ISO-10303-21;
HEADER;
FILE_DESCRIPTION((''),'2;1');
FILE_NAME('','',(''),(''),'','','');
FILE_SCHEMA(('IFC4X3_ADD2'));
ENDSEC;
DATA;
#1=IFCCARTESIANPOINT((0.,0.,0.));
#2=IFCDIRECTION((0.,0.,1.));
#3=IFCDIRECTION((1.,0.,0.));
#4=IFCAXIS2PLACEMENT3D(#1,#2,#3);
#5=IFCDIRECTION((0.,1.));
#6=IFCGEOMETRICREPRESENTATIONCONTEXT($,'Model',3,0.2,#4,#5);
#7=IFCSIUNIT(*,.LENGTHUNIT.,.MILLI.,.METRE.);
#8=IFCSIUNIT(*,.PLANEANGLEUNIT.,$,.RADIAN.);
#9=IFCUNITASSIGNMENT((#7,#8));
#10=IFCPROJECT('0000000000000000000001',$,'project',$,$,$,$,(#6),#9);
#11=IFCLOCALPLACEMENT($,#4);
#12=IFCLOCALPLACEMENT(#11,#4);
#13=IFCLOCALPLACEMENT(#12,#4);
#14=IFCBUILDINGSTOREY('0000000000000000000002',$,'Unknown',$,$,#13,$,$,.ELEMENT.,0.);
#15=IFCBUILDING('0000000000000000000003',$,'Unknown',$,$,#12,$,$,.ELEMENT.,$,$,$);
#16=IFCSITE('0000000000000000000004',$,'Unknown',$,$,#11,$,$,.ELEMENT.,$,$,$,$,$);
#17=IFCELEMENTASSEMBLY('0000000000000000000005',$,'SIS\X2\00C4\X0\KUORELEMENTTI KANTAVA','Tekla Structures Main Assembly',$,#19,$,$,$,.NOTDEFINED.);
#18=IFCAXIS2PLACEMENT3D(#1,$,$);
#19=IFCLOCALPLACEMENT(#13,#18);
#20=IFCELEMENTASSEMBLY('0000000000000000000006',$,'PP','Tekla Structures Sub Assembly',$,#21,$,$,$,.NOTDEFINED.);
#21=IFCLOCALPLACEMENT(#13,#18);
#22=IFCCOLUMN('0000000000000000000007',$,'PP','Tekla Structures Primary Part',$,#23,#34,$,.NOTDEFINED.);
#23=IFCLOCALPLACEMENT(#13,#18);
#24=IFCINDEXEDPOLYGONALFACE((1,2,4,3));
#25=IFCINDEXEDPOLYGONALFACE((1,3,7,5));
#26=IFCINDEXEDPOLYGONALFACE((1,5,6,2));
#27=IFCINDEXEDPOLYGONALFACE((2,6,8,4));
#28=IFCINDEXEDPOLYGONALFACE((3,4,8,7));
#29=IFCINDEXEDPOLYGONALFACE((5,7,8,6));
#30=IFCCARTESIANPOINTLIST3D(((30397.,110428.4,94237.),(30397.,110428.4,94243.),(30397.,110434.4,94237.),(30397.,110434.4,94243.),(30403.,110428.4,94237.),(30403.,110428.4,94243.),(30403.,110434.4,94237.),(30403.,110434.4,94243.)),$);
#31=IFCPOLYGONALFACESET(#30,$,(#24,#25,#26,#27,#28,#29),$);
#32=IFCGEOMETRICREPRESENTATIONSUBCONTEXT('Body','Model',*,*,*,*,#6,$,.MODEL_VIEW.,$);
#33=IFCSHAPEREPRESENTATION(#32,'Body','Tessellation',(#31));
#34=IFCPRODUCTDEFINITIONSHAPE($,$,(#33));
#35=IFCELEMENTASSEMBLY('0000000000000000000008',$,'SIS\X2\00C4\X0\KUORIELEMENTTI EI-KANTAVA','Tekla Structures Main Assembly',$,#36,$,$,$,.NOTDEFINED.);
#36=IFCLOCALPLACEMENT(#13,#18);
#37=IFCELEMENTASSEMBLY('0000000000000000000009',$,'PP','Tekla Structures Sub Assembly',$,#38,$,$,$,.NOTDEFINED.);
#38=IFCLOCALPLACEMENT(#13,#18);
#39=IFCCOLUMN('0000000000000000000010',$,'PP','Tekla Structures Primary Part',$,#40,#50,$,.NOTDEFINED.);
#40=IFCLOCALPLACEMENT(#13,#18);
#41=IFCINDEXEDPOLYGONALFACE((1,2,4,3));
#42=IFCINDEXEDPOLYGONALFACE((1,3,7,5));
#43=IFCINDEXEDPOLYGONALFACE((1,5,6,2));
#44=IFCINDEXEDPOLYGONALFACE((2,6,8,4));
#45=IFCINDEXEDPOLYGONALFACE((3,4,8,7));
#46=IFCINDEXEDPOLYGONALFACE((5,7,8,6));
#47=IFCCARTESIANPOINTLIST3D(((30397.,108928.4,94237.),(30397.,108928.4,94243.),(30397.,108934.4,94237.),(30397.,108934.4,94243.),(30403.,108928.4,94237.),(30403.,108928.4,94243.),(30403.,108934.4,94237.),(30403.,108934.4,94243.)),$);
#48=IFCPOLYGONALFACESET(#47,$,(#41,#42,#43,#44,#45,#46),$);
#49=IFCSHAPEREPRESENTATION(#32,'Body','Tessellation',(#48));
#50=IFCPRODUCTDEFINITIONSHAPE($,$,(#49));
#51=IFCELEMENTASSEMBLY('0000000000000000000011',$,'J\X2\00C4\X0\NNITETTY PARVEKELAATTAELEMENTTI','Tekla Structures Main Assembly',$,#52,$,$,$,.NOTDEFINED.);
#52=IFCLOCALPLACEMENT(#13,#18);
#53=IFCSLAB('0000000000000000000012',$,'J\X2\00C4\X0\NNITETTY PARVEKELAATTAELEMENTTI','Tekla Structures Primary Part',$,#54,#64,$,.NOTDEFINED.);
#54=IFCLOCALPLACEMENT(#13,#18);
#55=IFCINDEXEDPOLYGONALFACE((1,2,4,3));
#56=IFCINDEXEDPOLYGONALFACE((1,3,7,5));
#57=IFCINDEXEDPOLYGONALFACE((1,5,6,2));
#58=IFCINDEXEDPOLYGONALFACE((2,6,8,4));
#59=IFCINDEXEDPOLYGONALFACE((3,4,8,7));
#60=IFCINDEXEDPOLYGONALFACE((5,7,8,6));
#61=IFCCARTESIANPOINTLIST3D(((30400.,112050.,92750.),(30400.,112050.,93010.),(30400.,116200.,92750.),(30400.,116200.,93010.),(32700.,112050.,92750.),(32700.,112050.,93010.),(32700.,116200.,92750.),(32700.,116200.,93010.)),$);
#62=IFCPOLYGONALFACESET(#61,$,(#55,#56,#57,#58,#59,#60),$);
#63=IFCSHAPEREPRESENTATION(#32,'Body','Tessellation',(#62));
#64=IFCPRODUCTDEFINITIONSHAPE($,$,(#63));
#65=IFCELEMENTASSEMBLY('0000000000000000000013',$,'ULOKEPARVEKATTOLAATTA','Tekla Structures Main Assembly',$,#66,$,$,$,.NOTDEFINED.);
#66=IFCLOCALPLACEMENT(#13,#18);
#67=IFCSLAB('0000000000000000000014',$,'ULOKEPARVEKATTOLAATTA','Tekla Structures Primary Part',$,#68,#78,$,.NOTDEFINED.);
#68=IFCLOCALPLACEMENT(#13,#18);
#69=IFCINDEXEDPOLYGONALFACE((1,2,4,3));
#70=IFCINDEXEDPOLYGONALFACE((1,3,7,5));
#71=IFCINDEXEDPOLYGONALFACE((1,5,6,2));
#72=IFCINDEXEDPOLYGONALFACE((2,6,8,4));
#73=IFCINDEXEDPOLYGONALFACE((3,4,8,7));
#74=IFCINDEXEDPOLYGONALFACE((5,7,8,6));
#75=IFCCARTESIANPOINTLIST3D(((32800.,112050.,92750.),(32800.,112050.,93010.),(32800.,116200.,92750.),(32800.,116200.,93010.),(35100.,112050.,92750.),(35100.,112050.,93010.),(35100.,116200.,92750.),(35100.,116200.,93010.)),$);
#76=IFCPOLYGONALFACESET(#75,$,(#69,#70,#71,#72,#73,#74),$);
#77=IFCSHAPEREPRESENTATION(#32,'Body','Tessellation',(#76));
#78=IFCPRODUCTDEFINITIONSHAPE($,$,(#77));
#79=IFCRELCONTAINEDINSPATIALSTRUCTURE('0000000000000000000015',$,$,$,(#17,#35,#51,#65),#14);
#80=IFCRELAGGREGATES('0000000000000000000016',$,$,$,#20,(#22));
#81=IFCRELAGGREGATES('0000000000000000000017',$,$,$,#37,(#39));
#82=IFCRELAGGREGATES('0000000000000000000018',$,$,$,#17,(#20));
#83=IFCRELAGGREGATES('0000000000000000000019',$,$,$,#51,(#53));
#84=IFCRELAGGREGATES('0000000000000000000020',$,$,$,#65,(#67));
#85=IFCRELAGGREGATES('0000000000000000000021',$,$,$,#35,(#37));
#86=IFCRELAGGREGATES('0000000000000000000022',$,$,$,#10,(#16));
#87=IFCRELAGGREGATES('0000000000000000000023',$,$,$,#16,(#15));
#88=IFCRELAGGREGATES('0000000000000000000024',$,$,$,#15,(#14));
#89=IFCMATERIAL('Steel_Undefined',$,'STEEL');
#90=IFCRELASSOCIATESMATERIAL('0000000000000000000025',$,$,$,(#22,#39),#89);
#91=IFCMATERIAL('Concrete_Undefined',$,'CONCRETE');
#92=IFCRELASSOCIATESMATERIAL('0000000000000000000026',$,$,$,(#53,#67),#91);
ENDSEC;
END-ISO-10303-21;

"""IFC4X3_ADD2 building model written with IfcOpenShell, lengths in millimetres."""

from ifc_helpers import new_model, si_unit, direction, frame, origin_with_axes, place, context, subcontext, project, spatial, line, indexed_curve, outline, extrude, material, element, aggregate, save


model = new_model("IFC4X3_ADD2")

# Units and contexts
model_context = context("Model", 3, precision=0.2, world=origin_with_axes(), true_north=direction((0.0, 1.0)))
body_context = subcontext(model_context, "Body", "Model", "MODEL_VIEW")
ifc_project = project(units=[si_unit("LENGTHUNIT", "METRE", prefix="MILLI"), si_unit("PLANEANGLEUNIT", "RADIAN")], contexts=[model_context])

# Site, building, storey
site_placement = place(None, origin_with_axes())
site = spatial("IfcSite", under=ifc_project, at=site_placement, Name="Unknown", CompositionType="ELEMENT")
building_placement = place(site_placement, origin_with_axes())
building = spatial("IfcBuilding", under=site, at=building_placement, Name="Unknown", CompositionType="ELEMENT")
storey_placement = place(building_placement, origin_with_axes())
storey = spatial("IfcBuildingStorey", under=building, at=storey_placement, Name="Unknown", CompositionType="ELEMENT", Elevation=0.0)

# Element assemblies, columns
assembly_1_placement = place(storey_placement, frame((28000.0, 110431.4, 94240.0), z_axis=(0.0, -1.0, 0.0), x_axis=(1.0, 0.0, 0.0)))
assembly_1 = element("IfcElementAssembly", 1, at=assembly_1_placement, inside=storey, Name="SISÄKUORELEMENTTI KANTAVA", Description="Tekla Structures Main Assembly", PredefinedType="NOTDEFINED")
assembly_2_placement = place(assembly_1_placement, frame((2400.0, -3.0, 0.0), z_axis=(1.0, 0.0, 0.0), x_axis=(0.0, 1.0, 0.0)))
assembly_2 = element("IfcElementAssembly", 2, at=assembly_2_placement, Name="PP", Description="Tekla Structures Sub Assembly", PredefinedType="NOTDEFINED")
ifc_material_1 = material(Name="Steel_Undefined", Category="STEEL")
column_1_placement = place(assembly_2_placement, origin_with_axes())
column_1 = element("IfcColumn", 3, at=column_1_placement, material=ifc_material_1, Name="PP", Description="Tekla Structures Primary Part", PredefinedType="NOTDEFINED", context=body_context, shape_type="SolidModel", body=[
    extrude(outline(indexed_curve([(-3.0, -3.0), (3.0, -3.0), (3.0, 3.0), (-3.0, 3.0)], segments=[line(1, 2, 3, 4, 1)])), frame((0.0, 0.0, 0.0), z_axis=(-1.0, 0.0, 0.0), x_axis=(0.0, 0.0, 1.0)), (0.0, 0.0, -1.0), 6.0),
])
aggregate(assembly_2, [column_1])
assembly_3_placement = place(storey_placement, frame((28000.0, 108931.4, 94240.0), z_axis=(0.0, -1.0, 0.0), x_axis=(1.0, 0.0, 0.0)))
assembly_3 = element("IfcElementAssembly", 4, at=assembly_3_placement, inside=storey, Name="SISÄKUORIELEMENTTI EI-KANTAVA", Description="Tekla Structures Main Assembly", PredefinedType="NOTDEFINED")
assembly_4_placement = place(assembly_3_placement, frame((2400.0, -3.0, 0.0), z_axis=(1.0, 0.0, 0.0), x_axis=(0.0, 1.0, 0.0)))
assembly_4 = element("IfcElementAssembly", 5, at=assembly_4_placement, Name="PP", Description="Tekla Structures Sub Assembly", PredefinedType="NOTDEFINED")
column_2_placement = place(assembly_4_placement, origin_with_axes())
column_2 = element("IfcColumn", 6, at=column_2_placement, material=ifc_material_1, Name="PP", Description="Tekla Structures Primary Part", PredefinedType="NOTDEFINED", context=body_context, shape_type="SolidModel", body=[
    extrude(outline(indexed_curve([(-3.0, -3.0), (3.0, -3.0), (3.0, 3.0), (-3.0, 3.0)], segments=[line(1, 2, 3, 4, 1)])), frame((0.0, 0.0, 0.0), z_axis=(-1.0, 0.0, 0.0), x_axis=(0.0, 0.0, 1.0)), (0.0, 0.0, -1.0), 6.0),
])
aggregate(assembly_4, [column_2])

aggregate(assembly_1, [assembly_2])

# Element assemblies, slabs
assembly_5_placement = place(storey_placement, frame((30400.0, 112050.0, 92880.0), z_axis=(0.0, 0.0, 1.0), x_axis=(1.0, 0.0, 0.0)))
assembly_5 = element("IfcElementAssembly", 7, at=assembly_5_placement, inside=storey, Name="JÄNNITETTY PARVEKELAATTAELEMENTTI", Description="Tekla Structures Main Assembly", PredefinedType="NOTDEFINED")
ifc_material_2 = material(Name="Concrete_Undefined", Category="CONCRETE")
slab_1_placement = place(assembly_5_placement, origin_with_axes())
slab_1 = element("IfcSlab", 8, at=slab_1_placement, material=ifc_material_2, Name="JÄNNITETTY PARVEKELAATTAELEMENTTI", Description="Tekla Structures Primary Part", PredefinedType="NOTDEFINED", context=body_context, shape_type="SolidModel", body=[
    extrude(outline(indexed_curve([(0.0, 0.0), (2300.0, 0.0), (2300.0, 4150.0), (0.0, 4150.0)], segments=[line(1, 2, 3, 4, 1)])), frame((0.0, 0.0, 130.0), z_axis=(0.0, 0.0, 1.0), x_axis=(1.0, 0.0, 0.0)), (0.0, 0.0, -1.0), 260.0),
])
aggregate(assembly_5, [slab_1])
assembly_6_placement = place(storey_placement, frame((32800.0, 112050.0, 92880.0), z_axis=(0.0, 0.0, 1.0), x_axis=(1.0, 0.0, 0.0)))
assembly_6 = element("IfcElementAssembly", 9, at=assembly_6_placement, inside=storey, Name="ULOKEPARVEKATTOLAATTA", Description="Tekla Structures Main Assembly", PredefinedType="NOTDEFINED")
slab_2_placement = place(assembly_6_placement, origin_with_axes())
slab_2 = element("IfcSlab", 10, at=slab_2_placement, material=ifc_material_2, Name="ULOKEPARVEKATTOLAATTA", Description="Tekla Structures Primary Part", PredefinedType="NOTDEFINED", context=body_context, shape_type="SolidModel", body=[
    extrude(outline(indexed_curve([(0.0, 0.0), (2300.0, 0.0), (2300.0, 4150.0), (0.0, 4150.0)], segments=[line(1, 2, 3, 4, 1)])), frame((0.0, 0.0, 130.0), z_axis=(0.0, 0.0, 1.0), x_axis=(1.0, 0.0, 0.0)), (0.0, 0.0, -1.0), 260.0),
])
aggregate(assembly_6, [slab_2])

aggregate(assembly_3, [assembly_4])

save(model, "model.ifc")
